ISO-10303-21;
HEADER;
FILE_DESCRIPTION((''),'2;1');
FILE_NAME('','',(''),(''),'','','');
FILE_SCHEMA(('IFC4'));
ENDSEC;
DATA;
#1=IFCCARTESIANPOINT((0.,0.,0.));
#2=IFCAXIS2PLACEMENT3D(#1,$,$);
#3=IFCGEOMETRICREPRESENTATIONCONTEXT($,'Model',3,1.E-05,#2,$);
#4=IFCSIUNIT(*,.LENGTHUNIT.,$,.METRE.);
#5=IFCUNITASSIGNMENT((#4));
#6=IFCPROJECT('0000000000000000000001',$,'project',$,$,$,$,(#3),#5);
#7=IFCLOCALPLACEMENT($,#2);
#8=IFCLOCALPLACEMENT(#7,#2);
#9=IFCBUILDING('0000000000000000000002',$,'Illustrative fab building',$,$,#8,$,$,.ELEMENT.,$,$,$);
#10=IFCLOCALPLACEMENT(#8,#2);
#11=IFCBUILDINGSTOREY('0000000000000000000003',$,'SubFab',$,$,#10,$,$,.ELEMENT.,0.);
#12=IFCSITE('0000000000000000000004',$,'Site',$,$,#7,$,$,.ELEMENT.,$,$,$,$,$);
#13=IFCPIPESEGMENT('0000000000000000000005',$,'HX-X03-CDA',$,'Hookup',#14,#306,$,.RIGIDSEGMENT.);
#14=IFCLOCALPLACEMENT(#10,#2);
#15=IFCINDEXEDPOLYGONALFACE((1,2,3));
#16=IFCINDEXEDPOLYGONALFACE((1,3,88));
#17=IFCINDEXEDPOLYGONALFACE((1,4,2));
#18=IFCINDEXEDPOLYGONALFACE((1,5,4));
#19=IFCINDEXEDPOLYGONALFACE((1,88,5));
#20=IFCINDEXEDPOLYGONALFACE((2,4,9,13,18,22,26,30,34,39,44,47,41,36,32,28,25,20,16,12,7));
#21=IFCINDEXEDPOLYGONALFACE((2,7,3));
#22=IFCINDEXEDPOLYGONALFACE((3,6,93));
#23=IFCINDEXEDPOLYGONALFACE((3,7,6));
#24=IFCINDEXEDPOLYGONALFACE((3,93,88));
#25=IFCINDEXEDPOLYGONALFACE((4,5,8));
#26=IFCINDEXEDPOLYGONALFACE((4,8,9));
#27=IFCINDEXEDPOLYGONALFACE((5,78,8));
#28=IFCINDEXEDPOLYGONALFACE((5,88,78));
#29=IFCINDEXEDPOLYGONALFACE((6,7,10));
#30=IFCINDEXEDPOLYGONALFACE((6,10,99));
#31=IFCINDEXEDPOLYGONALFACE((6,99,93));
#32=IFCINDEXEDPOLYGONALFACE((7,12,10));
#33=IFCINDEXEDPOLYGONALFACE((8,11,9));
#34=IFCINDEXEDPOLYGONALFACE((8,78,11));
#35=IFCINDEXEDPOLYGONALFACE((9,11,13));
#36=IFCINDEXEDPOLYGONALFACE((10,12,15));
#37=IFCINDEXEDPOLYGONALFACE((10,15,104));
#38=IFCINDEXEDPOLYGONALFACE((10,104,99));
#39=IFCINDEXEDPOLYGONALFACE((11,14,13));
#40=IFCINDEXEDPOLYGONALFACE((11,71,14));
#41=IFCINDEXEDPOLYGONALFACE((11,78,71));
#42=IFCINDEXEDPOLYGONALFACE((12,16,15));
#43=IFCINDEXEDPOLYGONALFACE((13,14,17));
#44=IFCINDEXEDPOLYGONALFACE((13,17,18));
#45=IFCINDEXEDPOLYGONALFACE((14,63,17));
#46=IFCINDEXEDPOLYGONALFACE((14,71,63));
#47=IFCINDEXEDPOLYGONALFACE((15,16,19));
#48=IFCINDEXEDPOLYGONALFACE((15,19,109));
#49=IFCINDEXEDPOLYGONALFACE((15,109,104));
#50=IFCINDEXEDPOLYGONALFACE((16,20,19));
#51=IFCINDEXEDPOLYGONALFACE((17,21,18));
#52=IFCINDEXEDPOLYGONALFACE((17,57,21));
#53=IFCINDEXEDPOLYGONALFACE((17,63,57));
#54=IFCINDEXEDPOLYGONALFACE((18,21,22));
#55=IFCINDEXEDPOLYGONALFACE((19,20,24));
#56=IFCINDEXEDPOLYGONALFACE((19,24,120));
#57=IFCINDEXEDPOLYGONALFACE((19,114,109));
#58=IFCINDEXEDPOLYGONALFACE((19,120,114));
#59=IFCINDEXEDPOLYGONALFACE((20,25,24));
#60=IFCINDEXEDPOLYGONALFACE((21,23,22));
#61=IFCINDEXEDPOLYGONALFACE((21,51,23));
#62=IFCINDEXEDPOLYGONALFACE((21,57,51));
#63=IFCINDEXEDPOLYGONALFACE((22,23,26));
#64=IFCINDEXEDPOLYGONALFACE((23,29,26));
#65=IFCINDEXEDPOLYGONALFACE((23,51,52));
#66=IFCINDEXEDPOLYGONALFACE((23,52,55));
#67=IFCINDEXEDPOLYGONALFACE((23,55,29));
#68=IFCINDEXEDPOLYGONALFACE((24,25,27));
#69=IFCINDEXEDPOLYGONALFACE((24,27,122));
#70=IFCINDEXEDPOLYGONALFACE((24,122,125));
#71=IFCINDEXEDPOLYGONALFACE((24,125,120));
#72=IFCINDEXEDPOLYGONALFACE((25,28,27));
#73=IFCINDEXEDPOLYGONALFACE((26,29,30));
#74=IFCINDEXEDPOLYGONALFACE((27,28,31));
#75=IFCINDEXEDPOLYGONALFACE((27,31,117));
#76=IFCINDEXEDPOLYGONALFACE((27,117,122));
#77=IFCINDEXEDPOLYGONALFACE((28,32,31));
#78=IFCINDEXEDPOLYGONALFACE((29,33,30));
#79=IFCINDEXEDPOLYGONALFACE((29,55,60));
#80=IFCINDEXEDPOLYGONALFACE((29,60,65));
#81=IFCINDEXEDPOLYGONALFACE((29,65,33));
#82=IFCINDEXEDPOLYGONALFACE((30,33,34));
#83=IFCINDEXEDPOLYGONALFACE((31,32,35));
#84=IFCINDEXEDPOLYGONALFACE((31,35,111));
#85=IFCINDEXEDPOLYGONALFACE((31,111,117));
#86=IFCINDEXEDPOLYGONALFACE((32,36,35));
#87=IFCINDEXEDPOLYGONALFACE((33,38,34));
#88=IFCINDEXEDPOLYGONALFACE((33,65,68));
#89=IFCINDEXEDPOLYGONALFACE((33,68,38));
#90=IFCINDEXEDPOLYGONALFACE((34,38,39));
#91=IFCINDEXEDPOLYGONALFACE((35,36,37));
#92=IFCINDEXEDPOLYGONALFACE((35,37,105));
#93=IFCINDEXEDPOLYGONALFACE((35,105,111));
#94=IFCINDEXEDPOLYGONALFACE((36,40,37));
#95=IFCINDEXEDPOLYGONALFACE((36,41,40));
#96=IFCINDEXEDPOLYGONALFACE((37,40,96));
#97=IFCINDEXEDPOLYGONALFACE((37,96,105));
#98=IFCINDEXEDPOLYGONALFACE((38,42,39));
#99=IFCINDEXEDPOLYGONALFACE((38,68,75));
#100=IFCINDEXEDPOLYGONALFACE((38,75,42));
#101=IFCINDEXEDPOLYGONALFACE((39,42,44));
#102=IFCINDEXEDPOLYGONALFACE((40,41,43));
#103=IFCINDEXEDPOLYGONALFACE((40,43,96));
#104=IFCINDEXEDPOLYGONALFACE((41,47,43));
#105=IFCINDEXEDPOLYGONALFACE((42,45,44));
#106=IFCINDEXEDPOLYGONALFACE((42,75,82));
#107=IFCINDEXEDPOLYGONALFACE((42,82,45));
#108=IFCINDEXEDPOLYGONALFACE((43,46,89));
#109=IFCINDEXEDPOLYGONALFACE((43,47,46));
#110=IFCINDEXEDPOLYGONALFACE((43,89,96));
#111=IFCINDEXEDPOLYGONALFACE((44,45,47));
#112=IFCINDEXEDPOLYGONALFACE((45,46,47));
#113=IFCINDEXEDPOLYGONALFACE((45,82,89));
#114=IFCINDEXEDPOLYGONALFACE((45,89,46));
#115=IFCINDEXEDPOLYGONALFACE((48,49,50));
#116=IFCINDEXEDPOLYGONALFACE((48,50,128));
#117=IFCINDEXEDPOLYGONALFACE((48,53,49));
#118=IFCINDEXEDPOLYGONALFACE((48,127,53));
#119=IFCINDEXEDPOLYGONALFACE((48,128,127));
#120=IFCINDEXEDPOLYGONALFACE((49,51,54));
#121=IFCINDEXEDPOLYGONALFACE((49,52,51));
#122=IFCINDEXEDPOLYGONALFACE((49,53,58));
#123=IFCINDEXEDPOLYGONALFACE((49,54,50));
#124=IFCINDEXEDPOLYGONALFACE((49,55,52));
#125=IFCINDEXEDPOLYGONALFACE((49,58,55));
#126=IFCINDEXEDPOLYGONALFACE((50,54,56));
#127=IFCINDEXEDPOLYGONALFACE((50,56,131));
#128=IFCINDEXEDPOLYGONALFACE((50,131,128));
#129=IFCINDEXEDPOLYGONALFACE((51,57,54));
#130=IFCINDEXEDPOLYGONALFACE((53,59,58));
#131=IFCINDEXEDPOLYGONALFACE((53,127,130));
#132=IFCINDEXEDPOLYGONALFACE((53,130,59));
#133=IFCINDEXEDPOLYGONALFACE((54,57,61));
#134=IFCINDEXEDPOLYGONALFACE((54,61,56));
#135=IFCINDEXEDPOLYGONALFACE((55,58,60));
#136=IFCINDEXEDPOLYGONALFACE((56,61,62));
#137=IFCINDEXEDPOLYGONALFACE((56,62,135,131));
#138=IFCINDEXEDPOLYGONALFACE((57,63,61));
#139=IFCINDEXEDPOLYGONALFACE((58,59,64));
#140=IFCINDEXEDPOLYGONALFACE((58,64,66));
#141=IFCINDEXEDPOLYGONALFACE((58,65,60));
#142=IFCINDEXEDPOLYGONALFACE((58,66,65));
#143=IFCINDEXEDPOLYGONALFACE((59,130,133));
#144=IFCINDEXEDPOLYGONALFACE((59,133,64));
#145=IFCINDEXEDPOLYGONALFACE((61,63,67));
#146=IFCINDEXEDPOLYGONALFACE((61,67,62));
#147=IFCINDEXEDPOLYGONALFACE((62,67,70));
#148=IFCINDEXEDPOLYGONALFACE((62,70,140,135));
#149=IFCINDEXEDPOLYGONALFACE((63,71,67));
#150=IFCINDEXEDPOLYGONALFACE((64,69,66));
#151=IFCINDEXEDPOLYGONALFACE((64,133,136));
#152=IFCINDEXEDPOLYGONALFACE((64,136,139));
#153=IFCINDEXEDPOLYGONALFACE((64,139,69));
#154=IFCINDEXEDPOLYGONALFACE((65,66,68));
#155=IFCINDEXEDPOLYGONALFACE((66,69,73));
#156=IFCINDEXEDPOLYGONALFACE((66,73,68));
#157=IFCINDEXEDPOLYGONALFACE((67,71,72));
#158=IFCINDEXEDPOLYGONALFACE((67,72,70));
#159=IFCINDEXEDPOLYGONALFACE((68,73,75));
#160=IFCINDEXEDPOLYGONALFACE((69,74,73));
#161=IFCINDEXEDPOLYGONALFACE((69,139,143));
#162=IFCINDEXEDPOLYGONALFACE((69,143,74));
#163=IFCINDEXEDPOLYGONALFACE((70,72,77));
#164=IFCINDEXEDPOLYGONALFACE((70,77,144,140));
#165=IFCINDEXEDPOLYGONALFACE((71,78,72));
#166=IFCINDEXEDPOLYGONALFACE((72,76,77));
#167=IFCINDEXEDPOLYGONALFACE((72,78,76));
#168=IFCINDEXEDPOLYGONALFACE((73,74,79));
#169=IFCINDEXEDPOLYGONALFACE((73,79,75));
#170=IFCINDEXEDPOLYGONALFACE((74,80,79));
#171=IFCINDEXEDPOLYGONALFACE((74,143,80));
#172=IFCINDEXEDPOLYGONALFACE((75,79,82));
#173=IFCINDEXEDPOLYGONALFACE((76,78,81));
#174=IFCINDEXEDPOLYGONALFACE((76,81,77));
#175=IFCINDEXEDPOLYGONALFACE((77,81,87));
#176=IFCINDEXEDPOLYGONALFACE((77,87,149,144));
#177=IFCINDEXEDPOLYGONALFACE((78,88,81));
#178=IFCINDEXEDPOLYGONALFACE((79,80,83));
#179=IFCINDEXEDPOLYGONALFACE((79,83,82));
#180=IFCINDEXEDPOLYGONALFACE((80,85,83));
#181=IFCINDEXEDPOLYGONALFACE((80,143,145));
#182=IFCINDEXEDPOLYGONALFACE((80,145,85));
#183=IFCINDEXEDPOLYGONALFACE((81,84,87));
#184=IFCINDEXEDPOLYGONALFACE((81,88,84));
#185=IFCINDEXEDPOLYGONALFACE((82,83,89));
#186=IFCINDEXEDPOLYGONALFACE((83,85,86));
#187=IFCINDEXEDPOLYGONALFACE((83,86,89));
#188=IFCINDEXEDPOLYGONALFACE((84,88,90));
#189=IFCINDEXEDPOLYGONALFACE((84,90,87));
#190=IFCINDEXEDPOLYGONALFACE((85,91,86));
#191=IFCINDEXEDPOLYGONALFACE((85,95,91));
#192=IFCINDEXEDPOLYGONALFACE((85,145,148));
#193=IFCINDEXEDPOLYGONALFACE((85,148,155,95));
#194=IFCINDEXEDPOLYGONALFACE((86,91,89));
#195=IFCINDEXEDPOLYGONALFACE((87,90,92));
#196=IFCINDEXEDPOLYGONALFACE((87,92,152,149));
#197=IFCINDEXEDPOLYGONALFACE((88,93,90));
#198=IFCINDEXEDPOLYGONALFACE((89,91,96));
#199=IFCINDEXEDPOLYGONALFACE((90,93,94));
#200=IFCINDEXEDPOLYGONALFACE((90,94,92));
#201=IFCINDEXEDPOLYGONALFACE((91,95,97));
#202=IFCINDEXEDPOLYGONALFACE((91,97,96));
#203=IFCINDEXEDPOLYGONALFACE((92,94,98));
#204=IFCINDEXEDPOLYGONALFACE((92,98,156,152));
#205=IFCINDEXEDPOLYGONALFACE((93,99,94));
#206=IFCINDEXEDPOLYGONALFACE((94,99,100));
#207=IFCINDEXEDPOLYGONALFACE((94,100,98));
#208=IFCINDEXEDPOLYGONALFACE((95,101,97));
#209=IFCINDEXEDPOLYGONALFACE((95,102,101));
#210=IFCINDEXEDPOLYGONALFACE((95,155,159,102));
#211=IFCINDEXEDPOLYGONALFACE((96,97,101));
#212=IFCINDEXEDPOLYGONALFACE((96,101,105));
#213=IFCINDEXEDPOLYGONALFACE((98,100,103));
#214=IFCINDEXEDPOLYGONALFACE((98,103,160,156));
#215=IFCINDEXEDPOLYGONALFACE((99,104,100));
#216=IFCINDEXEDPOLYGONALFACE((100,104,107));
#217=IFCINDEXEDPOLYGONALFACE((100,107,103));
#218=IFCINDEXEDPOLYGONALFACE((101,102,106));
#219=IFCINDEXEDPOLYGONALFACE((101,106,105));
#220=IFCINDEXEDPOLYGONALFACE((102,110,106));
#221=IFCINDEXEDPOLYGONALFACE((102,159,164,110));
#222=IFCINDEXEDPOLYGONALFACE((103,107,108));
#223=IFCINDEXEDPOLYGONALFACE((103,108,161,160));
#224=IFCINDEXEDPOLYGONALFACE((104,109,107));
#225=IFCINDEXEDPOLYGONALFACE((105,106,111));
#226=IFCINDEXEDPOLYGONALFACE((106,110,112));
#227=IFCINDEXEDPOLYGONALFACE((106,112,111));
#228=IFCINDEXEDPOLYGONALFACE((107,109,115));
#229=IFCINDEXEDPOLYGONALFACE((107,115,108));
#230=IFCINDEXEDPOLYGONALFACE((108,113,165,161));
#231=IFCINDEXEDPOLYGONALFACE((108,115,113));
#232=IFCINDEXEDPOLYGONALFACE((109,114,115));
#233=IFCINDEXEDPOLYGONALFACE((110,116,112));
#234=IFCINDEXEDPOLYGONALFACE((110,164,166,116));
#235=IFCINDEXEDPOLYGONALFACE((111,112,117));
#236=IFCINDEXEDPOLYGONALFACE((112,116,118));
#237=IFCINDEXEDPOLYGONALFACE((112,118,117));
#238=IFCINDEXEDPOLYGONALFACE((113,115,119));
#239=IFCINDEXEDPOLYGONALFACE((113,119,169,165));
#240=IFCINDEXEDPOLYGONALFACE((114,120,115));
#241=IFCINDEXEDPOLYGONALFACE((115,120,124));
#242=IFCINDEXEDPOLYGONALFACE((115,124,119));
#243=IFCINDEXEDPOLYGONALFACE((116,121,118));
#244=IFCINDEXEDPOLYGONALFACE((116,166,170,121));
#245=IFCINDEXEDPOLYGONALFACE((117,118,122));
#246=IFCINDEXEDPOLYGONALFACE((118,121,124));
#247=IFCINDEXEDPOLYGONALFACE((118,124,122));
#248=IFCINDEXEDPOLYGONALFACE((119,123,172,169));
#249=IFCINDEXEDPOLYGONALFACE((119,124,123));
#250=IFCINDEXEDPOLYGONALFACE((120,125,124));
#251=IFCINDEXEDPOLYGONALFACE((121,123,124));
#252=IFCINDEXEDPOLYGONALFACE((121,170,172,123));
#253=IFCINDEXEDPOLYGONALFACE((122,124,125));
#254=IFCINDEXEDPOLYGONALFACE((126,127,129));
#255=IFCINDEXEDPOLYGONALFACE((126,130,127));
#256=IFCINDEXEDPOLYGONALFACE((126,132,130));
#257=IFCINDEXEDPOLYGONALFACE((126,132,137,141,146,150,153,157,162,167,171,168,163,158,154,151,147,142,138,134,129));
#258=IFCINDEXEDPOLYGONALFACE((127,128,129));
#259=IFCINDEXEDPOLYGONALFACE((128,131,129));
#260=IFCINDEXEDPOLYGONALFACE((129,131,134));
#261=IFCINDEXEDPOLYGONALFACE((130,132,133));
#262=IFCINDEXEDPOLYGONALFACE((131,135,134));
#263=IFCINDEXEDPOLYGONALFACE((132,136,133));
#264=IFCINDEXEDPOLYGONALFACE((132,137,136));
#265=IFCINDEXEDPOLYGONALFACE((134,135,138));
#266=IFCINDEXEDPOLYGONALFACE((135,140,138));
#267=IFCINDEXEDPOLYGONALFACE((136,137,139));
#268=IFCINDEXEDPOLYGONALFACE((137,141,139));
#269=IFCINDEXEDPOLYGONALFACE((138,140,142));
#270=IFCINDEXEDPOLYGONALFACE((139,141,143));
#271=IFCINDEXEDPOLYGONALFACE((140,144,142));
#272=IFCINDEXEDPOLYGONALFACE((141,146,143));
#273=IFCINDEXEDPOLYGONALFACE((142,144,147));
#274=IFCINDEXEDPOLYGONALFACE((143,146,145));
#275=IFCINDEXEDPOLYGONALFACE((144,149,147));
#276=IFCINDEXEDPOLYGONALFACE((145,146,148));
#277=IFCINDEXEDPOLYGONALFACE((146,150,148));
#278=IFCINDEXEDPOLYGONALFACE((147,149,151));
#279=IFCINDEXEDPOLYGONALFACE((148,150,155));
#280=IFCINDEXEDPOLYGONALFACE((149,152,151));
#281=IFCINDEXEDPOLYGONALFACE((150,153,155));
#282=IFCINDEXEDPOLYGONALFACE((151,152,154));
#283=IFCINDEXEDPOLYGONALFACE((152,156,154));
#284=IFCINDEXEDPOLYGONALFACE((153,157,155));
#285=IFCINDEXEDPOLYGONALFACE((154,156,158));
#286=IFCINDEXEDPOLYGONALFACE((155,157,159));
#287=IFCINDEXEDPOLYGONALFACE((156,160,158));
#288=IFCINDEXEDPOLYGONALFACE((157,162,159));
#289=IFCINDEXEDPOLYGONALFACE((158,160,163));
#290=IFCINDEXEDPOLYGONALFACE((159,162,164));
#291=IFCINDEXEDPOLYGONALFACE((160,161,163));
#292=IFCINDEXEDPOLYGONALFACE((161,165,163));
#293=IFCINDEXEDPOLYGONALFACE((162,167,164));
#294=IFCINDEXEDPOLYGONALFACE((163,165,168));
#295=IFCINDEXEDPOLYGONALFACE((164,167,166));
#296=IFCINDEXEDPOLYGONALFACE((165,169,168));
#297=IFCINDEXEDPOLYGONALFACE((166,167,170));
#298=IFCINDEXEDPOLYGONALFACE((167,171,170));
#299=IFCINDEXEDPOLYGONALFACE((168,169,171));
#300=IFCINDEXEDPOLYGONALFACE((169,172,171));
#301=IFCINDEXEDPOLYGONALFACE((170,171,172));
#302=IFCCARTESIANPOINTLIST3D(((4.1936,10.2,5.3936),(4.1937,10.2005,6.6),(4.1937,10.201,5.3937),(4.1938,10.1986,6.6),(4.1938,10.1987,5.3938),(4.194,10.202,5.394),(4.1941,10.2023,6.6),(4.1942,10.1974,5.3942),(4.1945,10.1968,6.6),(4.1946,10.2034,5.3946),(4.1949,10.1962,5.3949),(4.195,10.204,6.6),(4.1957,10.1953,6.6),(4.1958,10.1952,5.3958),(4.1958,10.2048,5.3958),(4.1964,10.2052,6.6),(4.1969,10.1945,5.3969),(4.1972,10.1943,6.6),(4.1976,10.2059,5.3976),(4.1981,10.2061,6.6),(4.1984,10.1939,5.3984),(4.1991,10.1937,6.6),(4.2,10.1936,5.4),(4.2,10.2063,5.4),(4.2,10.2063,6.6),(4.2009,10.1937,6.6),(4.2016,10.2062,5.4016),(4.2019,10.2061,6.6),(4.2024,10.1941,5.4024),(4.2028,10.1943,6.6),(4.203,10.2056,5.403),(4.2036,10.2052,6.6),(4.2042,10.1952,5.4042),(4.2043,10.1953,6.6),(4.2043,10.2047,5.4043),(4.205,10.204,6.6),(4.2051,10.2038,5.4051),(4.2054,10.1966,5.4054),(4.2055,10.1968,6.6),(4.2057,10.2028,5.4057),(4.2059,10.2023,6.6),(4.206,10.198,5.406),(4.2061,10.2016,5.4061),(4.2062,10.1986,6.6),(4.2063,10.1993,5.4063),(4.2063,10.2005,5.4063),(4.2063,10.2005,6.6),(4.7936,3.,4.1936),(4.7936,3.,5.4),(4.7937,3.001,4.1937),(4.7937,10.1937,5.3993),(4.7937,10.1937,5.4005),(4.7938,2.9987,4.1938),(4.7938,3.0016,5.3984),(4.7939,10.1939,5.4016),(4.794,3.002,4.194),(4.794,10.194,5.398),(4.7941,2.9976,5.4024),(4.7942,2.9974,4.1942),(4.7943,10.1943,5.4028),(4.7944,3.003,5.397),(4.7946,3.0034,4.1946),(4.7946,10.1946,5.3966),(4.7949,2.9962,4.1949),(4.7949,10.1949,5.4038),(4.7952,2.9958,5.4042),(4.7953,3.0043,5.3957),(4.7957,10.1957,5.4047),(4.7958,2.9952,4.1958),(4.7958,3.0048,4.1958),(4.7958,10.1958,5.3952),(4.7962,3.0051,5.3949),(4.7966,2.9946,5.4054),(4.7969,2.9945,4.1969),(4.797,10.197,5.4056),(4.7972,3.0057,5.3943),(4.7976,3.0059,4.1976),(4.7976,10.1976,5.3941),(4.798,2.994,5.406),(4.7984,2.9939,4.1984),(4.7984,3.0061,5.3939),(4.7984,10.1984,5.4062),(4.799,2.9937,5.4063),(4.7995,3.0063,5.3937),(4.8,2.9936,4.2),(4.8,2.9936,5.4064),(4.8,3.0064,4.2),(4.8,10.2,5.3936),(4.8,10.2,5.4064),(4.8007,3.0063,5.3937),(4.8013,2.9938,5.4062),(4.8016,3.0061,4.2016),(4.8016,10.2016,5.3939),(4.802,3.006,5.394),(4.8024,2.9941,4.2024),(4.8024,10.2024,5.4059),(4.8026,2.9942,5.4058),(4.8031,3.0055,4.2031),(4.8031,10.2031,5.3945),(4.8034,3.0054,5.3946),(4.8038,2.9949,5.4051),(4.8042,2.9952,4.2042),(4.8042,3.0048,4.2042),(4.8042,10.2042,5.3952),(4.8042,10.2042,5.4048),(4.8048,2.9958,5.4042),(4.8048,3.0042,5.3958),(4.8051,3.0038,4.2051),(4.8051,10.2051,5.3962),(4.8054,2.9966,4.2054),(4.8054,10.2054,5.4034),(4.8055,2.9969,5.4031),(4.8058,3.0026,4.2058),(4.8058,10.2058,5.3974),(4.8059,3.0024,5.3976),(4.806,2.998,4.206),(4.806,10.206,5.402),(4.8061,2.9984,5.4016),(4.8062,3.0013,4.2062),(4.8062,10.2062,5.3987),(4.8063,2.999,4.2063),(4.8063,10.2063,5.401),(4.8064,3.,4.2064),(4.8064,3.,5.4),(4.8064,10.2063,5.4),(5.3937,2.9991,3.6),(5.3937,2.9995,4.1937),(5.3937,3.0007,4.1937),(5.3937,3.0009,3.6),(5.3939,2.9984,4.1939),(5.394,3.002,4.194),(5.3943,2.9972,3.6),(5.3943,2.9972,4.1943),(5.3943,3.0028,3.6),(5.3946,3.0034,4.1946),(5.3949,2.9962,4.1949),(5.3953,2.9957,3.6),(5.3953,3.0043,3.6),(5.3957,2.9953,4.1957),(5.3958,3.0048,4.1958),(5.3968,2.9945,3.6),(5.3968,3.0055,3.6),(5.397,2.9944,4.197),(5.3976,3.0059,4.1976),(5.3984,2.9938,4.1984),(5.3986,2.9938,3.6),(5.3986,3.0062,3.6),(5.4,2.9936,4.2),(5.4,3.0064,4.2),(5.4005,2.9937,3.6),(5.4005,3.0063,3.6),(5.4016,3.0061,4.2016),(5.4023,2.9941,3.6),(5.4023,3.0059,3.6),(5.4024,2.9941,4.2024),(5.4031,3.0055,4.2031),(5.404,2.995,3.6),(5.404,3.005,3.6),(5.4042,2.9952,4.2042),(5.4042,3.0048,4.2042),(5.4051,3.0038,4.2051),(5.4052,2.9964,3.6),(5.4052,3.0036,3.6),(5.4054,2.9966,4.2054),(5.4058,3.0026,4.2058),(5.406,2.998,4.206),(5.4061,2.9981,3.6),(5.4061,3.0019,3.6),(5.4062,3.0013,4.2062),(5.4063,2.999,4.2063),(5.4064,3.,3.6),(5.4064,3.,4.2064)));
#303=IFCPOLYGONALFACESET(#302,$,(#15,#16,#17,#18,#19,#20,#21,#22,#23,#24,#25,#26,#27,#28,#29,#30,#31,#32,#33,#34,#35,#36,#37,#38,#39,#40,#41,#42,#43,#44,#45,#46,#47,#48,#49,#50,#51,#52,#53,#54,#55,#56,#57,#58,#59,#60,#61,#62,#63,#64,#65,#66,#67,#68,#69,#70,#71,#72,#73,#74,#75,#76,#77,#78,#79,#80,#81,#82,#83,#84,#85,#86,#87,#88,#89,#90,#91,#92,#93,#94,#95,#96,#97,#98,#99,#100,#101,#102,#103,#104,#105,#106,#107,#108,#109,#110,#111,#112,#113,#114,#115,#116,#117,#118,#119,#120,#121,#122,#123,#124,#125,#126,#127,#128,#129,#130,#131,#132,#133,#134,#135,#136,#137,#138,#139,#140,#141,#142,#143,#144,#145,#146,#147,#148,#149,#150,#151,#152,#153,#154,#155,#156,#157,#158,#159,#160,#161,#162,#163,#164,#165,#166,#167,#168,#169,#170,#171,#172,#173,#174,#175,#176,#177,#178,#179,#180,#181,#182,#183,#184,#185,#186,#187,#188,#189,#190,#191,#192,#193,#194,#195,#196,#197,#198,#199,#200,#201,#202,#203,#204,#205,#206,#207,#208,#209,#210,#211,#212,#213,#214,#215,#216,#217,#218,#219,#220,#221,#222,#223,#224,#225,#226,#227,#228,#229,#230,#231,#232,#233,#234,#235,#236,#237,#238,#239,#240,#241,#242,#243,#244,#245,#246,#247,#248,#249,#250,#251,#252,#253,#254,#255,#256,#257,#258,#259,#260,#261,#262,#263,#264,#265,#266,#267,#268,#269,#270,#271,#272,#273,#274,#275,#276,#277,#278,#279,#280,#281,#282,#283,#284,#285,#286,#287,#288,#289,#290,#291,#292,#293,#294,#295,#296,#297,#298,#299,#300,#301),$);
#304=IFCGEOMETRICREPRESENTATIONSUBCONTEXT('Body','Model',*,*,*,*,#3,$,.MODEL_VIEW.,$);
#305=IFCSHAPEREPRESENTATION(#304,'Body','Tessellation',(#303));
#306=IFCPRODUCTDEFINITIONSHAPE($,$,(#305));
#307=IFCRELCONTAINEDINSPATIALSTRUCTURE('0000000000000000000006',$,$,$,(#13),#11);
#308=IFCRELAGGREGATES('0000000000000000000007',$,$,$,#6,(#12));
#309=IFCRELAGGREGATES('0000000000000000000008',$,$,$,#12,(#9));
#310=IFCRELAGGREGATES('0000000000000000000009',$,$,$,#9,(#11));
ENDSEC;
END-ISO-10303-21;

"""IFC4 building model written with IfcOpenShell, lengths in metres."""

from ifc_helpers import new_model, entity, si_unit, origin, place, context, subcontext, project, spatial, element, save


model = new_model("IFC4")

# Units and contexts
model_context = context("Model", 3, precision=1e-05, world=origin())
body_context = subcontext(model_context, "Body", "Model", "MODEL_VIEW")
ifc_project = project(units=[si_unit("LENGTHUNIT", "METRE")], contexts=[model_context])

# Site, building, storey
site_placement = place(None, origin())
site = spatial("IfcSite", under=ifc_project, at=site_placement, Name="Site", CompositionType="ELEMENT")
building_placement = place(site_placement, origin())
building = spatial("IfcBuilding", under=site, at=building_placement, Name="Illustrative fab building", CompositionType="ELEMENT")
storey_placement = place(building_placement, origin())
storey = spatial("IfcBuildingStorey", under=building, at=storey_placement, Name="SubFab", CompositionType="ELEMENT", Elevation=0.0)

# Pipe segment
pipe_segment_1_placement = place(storey_placement, origin())
element("IfcPipeSegment", 1, at=pipe_segment_1_placement, inside=storey, Name="HX-X03-CDA", ObjectType="Hookup", PredefinedType="RIGIDSEGMENT", context=body_context, shape_type="AdvancedSweptSolid", body=[
    entity("IfcSweptDiskSolid", entity("IfcPolyline", [entity("IfcCartesianPoint", [5.4, 3.0, 3.6]), entity("IfcCartesianPoint", [5.4, 3.0, 4.2]), entity("IfcCartesianPoint", [4.8, 3.0, 4.2]), entity("IfcCartesianPoint", [4.8, 3.0, 5.4]), entity("IfcCartesianPoint", [4.8, 10.2, 5.4]), entity("IfcCartesianPoint", [4.2, 10.2, 5.4]), entity("IfcCartesianPoint", [4.2, 10.2, 6.6])]), 0.0063),
])

save(model, "model.ifc")
